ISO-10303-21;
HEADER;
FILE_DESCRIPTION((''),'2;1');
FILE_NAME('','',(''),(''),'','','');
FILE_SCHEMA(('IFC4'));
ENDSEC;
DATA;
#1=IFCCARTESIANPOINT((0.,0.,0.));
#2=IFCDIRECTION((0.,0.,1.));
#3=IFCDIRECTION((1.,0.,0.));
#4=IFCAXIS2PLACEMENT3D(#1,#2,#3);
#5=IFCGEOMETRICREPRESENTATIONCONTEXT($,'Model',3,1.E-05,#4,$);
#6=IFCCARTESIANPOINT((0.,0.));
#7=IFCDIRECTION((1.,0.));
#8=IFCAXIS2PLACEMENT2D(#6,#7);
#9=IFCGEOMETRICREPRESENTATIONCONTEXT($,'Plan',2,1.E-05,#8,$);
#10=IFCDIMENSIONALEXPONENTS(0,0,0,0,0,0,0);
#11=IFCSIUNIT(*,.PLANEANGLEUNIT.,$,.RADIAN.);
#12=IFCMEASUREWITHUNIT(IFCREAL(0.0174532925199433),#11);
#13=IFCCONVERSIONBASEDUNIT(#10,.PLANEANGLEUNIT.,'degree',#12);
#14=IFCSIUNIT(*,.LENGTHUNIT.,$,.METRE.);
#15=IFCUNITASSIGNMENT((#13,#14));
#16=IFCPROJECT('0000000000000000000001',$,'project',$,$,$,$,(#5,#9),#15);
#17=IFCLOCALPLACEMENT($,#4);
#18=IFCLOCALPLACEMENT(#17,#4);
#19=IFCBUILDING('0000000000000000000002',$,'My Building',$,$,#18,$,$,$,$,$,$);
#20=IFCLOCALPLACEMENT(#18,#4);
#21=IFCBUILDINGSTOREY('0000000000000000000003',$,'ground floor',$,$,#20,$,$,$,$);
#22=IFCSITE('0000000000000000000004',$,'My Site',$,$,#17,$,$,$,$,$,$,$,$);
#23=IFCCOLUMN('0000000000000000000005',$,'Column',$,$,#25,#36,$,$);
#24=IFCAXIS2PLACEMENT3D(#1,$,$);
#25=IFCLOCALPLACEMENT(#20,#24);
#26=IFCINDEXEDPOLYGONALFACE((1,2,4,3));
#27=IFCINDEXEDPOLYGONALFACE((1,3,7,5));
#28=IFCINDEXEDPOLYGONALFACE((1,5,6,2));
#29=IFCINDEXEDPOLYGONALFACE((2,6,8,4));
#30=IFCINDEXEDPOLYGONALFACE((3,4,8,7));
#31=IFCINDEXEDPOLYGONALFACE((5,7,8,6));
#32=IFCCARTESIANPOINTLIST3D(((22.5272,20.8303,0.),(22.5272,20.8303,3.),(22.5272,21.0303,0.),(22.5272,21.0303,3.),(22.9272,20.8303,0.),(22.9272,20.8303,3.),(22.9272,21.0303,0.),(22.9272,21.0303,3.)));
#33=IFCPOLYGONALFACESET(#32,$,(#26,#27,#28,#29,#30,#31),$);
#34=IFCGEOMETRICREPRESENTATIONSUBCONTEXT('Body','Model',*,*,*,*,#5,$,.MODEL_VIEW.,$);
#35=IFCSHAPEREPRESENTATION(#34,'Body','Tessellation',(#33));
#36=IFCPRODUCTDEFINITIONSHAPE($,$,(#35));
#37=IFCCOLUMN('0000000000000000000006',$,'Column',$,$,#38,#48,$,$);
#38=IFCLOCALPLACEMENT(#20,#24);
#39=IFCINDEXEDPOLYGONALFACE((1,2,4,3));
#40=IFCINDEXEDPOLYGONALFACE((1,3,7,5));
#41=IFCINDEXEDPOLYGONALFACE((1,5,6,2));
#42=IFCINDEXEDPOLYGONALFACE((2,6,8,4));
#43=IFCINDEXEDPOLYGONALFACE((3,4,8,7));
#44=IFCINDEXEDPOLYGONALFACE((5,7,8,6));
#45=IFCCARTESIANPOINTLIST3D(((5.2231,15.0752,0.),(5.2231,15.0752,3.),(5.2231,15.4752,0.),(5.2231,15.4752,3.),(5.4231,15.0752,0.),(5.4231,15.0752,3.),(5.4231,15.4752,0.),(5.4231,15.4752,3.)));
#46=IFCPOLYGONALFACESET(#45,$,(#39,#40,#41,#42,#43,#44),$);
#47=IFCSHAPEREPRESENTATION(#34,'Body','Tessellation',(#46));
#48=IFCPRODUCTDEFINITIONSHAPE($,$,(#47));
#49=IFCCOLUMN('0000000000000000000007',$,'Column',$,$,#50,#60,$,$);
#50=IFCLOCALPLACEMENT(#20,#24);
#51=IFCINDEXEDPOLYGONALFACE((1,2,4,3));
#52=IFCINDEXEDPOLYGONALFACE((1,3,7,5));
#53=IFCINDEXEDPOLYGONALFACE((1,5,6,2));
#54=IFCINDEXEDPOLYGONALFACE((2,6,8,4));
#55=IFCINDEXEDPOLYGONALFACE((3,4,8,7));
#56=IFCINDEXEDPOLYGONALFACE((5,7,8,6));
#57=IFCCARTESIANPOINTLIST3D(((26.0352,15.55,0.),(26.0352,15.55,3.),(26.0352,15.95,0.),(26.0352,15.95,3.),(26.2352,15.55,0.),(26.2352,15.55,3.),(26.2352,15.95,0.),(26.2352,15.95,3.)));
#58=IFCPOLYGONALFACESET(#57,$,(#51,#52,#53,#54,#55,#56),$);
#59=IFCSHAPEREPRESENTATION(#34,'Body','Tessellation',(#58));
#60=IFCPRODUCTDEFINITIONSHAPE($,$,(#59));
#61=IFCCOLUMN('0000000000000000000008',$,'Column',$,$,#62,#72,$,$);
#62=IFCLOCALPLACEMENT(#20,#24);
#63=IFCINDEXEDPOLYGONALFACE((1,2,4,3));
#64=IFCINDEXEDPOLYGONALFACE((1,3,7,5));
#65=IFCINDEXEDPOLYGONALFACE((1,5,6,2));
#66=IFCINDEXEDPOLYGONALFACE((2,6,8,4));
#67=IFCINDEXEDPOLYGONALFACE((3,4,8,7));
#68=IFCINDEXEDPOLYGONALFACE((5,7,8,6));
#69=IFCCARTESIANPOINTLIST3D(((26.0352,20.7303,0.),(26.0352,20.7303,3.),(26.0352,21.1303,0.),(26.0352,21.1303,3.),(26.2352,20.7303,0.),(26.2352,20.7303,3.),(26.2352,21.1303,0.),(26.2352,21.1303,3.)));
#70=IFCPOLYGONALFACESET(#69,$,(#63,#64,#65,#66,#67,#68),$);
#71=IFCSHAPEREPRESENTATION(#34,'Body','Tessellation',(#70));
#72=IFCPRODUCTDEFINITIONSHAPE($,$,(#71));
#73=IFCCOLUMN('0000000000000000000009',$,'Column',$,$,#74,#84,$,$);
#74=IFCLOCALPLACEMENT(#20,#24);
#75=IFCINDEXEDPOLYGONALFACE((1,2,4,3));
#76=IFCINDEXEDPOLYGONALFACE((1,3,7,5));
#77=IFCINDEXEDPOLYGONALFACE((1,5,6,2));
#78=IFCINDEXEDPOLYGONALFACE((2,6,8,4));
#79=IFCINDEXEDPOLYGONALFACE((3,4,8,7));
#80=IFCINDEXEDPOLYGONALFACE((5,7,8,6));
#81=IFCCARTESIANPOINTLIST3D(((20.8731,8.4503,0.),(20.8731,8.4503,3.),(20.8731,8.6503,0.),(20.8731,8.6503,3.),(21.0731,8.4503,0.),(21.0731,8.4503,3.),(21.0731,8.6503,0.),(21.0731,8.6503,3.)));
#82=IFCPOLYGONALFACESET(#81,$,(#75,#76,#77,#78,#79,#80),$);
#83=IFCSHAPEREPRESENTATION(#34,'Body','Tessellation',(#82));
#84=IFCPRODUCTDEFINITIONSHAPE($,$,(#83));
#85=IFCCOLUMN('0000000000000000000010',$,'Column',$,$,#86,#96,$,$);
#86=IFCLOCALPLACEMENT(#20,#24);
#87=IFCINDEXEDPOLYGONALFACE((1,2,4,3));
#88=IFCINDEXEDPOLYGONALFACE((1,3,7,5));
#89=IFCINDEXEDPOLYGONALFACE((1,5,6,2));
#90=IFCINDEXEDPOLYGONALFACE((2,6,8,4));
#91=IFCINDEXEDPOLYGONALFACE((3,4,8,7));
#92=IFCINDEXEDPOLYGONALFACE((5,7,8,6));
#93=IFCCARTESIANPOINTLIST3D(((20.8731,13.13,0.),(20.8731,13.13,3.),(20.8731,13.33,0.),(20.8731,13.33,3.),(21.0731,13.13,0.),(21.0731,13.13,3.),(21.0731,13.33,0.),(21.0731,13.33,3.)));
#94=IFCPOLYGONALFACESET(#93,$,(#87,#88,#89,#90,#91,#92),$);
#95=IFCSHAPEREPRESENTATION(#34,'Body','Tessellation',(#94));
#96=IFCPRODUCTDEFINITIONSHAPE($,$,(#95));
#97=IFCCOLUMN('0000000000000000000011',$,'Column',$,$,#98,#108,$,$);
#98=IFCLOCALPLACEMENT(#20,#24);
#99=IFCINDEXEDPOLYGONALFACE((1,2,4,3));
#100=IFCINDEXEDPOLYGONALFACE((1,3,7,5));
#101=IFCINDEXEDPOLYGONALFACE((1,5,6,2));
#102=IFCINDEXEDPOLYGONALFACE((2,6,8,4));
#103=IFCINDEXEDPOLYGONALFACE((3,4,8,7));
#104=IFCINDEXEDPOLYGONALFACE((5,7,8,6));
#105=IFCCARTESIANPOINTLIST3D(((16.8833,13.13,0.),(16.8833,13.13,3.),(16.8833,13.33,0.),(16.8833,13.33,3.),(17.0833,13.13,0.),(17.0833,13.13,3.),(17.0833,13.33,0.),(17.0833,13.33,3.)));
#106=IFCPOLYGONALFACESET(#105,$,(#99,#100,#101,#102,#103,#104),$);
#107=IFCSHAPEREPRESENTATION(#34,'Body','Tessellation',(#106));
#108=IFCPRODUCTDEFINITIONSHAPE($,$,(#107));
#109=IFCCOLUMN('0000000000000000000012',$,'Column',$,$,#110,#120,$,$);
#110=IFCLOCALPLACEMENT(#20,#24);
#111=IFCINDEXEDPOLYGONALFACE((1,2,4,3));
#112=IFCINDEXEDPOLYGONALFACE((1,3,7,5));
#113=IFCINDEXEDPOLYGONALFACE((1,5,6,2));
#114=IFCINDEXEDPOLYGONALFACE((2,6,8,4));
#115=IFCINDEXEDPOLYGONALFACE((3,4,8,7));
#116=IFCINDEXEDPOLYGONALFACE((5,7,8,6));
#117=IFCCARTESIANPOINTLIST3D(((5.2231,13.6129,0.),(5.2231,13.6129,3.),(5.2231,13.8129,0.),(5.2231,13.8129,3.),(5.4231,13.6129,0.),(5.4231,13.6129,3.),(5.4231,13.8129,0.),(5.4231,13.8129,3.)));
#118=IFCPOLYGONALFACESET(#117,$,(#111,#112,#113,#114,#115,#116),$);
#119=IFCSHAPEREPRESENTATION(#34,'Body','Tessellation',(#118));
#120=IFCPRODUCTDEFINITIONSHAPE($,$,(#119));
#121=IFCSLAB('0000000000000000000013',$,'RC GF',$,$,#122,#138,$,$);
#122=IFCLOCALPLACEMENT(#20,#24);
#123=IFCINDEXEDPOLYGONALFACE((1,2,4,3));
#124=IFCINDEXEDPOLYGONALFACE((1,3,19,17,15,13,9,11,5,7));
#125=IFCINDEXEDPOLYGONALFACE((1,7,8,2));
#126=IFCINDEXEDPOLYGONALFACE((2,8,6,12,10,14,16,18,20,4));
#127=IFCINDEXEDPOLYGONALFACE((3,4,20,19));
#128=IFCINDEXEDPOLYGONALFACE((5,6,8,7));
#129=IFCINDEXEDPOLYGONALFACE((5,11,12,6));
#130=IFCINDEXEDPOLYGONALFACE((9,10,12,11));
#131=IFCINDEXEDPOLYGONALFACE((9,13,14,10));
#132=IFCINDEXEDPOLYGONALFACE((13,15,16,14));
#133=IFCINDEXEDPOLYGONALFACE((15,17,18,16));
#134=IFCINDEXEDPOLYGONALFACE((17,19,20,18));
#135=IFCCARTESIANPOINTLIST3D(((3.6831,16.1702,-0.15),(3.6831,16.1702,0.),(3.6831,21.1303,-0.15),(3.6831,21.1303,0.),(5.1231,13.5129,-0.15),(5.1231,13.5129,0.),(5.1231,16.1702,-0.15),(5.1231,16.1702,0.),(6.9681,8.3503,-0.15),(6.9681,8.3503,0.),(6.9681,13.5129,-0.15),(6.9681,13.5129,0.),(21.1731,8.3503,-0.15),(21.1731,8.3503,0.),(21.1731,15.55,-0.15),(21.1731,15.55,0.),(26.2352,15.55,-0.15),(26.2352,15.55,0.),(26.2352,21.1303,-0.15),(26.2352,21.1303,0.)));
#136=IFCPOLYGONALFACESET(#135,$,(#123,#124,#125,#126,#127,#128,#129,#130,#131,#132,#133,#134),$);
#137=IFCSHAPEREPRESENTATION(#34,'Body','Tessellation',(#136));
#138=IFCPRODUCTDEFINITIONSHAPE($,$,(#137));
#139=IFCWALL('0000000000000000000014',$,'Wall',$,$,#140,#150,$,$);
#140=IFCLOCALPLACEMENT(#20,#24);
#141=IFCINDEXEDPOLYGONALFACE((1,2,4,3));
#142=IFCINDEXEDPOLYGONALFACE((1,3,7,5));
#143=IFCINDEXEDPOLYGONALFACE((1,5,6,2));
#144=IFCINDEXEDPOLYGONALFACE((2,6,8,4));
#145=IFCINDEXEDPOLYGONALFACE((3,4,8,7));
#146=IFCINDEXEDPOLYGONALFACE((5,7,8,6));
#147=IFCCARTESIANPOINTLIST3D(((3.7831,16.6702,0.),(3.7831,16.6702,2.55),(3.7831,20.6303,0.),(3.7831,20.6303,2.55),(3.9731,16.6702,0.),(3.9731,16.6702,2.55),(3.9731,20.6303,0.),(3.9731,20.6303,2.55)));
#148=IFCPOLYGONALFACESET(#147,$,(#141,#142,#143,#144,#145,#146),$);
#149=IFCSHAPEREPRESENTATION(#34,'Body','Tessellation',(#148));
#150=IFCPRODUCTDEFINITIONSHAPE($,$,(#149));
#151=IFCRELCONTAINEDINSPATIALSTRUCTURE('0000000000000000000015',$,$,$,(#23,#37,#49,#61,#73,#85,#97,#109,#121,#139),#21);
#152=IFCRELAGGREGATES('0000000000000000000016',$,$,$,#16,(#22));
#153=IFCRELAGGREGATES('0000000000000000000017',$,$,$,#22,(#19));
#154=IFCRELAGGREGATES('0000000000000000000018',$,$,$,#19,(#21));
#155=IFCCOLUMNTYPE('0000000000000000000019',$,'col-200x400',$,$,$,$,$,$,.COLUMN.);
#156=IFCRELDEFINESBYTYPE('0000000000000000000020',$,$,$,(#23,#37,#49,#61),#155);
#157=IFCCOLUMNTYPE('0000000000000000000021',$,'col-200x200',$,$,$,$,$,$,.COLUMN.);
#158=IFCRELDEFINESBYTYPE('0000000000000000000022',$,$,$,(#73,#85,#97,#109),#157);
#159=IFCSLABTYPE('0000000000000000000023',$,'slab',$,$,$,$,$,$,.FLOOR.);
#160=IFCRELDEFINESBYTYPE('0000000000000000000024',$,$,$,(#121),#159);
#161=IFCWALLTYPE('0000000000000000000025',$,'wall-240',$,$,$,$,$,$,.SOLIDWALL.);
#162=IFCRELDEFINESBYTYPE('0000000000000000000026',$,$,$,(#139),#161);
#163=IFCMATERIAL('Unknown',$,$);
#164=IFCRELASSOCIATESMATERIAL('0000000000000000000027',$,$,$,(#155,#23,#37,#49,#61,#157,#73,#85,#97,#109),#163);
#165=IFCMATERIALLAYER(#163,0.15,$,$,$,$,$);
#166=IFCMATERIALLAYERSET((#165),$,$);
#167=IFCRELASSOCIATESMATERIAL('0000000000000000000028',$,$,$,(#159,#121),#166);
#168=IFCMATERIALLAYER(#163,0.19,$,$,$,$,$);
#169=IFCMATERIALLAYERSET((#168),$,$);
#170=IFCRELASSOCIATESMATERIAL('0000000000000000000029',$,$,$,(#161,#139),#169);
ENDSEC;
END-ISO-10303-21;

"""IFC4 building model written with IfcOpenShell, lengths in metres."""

from ifc_helpers import new_model, entity, si_unit, converted_unit, frame, origin_with_axes, origin_2d_with_axis, place, context, subcontext, project, spatial, line, indexed_curve, rectangle, outline, extrude, material, layer, layer_set, layer_usage, material_profile, profile_set, profile_usage, type_object, element, save


model = new_model("IFC4")

# Units and contexts
model_context = context("Model", 3, precision=1e-05, world=origin_with_axes())
plan_context = context("Plan", 2, precision=1e-05, world=origin_2d_with_axis())
body_context = subcontext(model_context, "Body", "Model", "MODEL_VIEW")
ifc_project = project(units=[converted_unit("PLANEANGLEUNIT", "degree", entity("IfcReal", 0.0174532925199433), si_unit("PLANEANGLEUNIT", "RADIAN"), dimensions=[0, 0, 0, 0, 0, 0, 0]), si_unit("LENGTHUNIT", "METRE")], contexts=[model_context, plan_context])

# Site, building, storey
site_placement = place(None, origin_with_axes())
site = spatial("IfcSite", under=ifc_project, at=site_placement, Name="My Site")
building_placement = place(site_placement, origin_with_axes())
building = spatial("IfcBuilding", under=site, at=building_placement, Name="My Building")
storey_placement = place(building_placement, origin_with_axes())
storey = spatial("IfcBuildingStorey", under=building, at=storey_placement, Name="ground floor")

# Columns
ifc_material = material(Name="Unknown")
ifc_material_profile_1 = material_profile(ifc_material, rectangle(XDim=0.2, YDim=0.4))
ifc_profile_set_1 = profile_set([ifc_material_profile_1])
column_type_1 = type_object("IfcColumnType", Name="col-200x400", PredefinedType="COLUMN", material=ifc_profile_set_1)
ifc_profile_usage_1 = profile_usage(ifc_profile_set_1, cardinal=1)
column_1_placement = place(storey_placement, frame((22.5272, 20.8303, 0.0), z_axis=(0.0, 0.0, 1.0), x_axis=(0.0, -1.0, 0.0)))
element("IfcColumn", 1, at=column_1_placement, inside=storey, type_object=column_type_1, material=ifc_profile_usage_1, Name="Column", context=body_context, shape_type="SweptSolid", body=[
    extrude(rectangle(XDim=0.2, YDim=0.4), frame((-0.1, 0.2, 0.0), z_axis=(0.0, 0.0, 1.0), x_axis=(1.0, 0.0, 0.0)), (0.0, 0.0, 1.0), 3.0),
])
ifc_profile_usage_2 = profile_usage(ifc_profile_set_1, cardinal=1)
column_2_placement = place(storey_placement, frame((5.4231, 15.0752, 0.0), z_axis=(0.0, 0.0, 1.0), x_axis=(1.0, 0.0, 0.0)))
element("IfcColumn", 2, at=column_2_placement, inside=storey, type_object=column_type_1, material=ifc_profile_usage_2, Name="Column", context=body_context, shape_type="SweptSolid", body=[
    extrude(rectangle(XDim=0.2, YDim=0.4), frame((-0.1, 0.2, 0.0), z_axis=(0.0, 0.0, 1.0), x_axis=(1.0, 0.0, 0.0)), (0.0, 0.0, 1.0), 3.0),
])
ifc_profile_usage_3 = profile_usage(ifc_profile_set_1, cardinal=1)
column_3_placement = place(storey_placement, frame((26.2352, 15.55, 0.0), z_axis=(0.0, 0.0, 1.0), x_axis=(1.0, 0.0, 0.0)))
element("IfcColumn", 3, at=column_3_placement, inside=storey, type_object=column_type_1, material=ifc_profile_usage_3, Name="Column", context=body_context, shape_type="SweptSolid", body=[
    extrude(rectangle(XDim=0.2, YDim=0.4), frame((-0.1, 0.2, 0.0), z_axis=(0.0, 0.0, 1.0), x_axis=(1.0, 0.0, 0.0)), (0.0, 0.0, 1.0), 3.0),
])
ifc_profile_usage_4 = profile_usage(ifc_profile_set_1, cardinal=1)
column_4_placement = place(storey_placement, frame((26.2352, 20.7303, 0.0), z_axis=(0.0, 0.0, 1.0), x_axis=(1.0, 0.0, 0.0)))
element("IfcColumn", 4, at=column_4_placement, inside=storey, type_object=column_type_1, material=ifc_profile_usage_4, Name="Column", context=body_context, shape_type="SweptSolid", body=[
    extrude(rectangle(XDim=0.2, YDim=0.4), frame((-0.1, 0.2, 0.0), z_axis=(0.0, 0.0, 1.0), x_axis=(1.0, 0.0, 0.0)), (0.0, 0.0, 1.0), 3.0),
])
ifc_material_profile_2 = material_profile(ifc_material, rectangle(XDim=0.2, YDim=0.2))
ifc_profile_set_2 = profile_set([ifc_material_profile_2])
ifc_profile_usage_5 = profile_usage(ifc_profile_set_2, cardinal=1)
column_type_2 = type_object("IfcColumnType", Name="col-200x200", PredefinedType="COLUMN", material=ifc_profile_set_2)
column_5_placement = place(storey_placement, frame((21.0731, 8.4503, 0.0), z_axis=(0.0, 0.0, 1.0), x_axis=(1.0, 0.0, 0.0)))
element("IfcColumn", 5, at=column_5_placement, inside=storey, type_object=column_type_2, material=ifc_profile_usage_5, Name="Column", context=body_context, shape_type="SweptSolid", body=[
    extrude(rectangle(XDim=0.2, YDim=0.2), frame((-0.1, 0.1, 0.0), z_axis=(0.0, 0.0, 1.0), x_axis=(1.0, 0.0, 0.0)), (0.0, 0.0, 1.0), 3.0),
])
ifc_profile_usage_6 = profile_usage(ifc_profile_set_2, cardinal=1)
column_6_placement = place(storey_placement, frame((21.0731, 13.13, 0.0), z_axis=(0.0, 0.0, 1.0), x_axis=(1.0, 0.0, 0.0)))
element("IfcColumn", 6, at=column_6_placement, inside=storey, type_object=column_type_2, material=ifc_profile_usage_6, Name="Column", context=body_context, shape_type="SweptSolid", body=[
    extrude(rectangle(XDim=0.2, YDim=0.2), frame((-0.1, 0.1, 0.0), z_axis=(0.0, 0.0, 1.0), x_axis=(1.0, 0.0, 0.0)), (0.0, 0.0, 1.0), 3.0),
])
ifc_profile_usage_7 = profile_usage(ifc_profile_set_2, cardinal=1)
column_7_placement = place(storey_placement, frame((17.0833, 13.13, 0.0), z_axis=(0.0, 0.0, 1.0), x_axis=(1.0, 0.0, 0.0)))
element("IfcColumn", 7, at=column_7_placement, inside=storey, type_object=column_type_2, material=ifc_profile_usage_7, Name="Column", context=body_context, shape_type="SweptSolid", body=[
    extrude(rectangle(XDim=0.2, YDim=0.2), frame((-0.1, 0.1, 0.0), z_axis=(0.0, 0.0, 1.0), x_axis=(1.0, 0.0, 0.0)), (0.0, 0.0, 1.0), 3.0),
])
ifc_profile_usage_8 = profile_usage(ifc_profile_set_2, cardinal=1)
column_8_placement = place(storey_placement, frame((5.4231, 13.6129, 0.0), z_axis=(0.0, 0.0, 1.0), x_axis=(1.0, 0.0, 0.0)))
element("IfcColumn", 8, at=column_8_placement, inside=storey, type_object=column_type_2, material=ifc_profile_usage_8, Name="Column", context=body_context, shape_type="SweptSolid", body=[
    extrude(rectangle(XDim=0.2, YDim=0.2), frame((-0.1, 0.1, 0.0), z_axis=(0.0, 0.0, 1.0), x_axis=(1.0, 0.0, 0.0)), (0.0, 0.0, 1.0), 3.0),
])

# Slab
ifc_layer_1 = layer(ifc_material, 0.15)
ifc_layer_set_1 = layer_set([ifc_layer_1])
ifc_layer_usage_1 = layer_usage(ifc_layer_set_1, "AXIS3", "POSITIVE", 0.0)
slab_type = type_object("IfcSlabType", Name="slab", PredefinedType="FLOOR", material=ifc_layer_set_1)
slab_placement = place(storey_placement, frame((6.9681, 8.3503, -0.15), z_axis=(0.0, 0.0, 1.0), x_axis=(1.0, 0.0, 0.0)))
element("IfcSlab", 9, at=slab_placement, inside=storey, type_object=slab_type, material=ifc_layer_usage_1, Name="RC GF", context=body_context, shape_type="SweptSolid", body=[
    extrude(outline(indexed_curve([(14.205, 7.1996), (19.2671, 7.1996), (19.2671, 12.78), (-3.285, 12.78), (-3.285, 7.8199), (-1.845, 7.8199), (-1.845, 5.1626), (0.0, 5.1626), (0.0, 0.0), (14.205, 0.0)], segments=[line(3, 2), line(2, 1), line(1, 10), line(10, 9), line(9, 8), line(8, 7), line(7, 6), line(6, 5), line(5, 4), line(4, 3)], self_intersect=False)), None, (0.0, 0.0, 1.0), 0.15),
])

# Wall
ifc_layer_2 = layer(ifc_material, 0.19)
ifc_layer_set_2 = layer_set([ifc_layer_2])
ifc_layer_usage_2 = layer_usage(ifc_layer_set_2, "AXIS2", "POSITIVE", 0.0)
wall_type = type_object("IfcWallType", Name="wall-240", PredefinedType="SOLIDWALL", material=ifc_layer_set_2)
wall_placement = place(storey_placement, frame((3.7831, 20.6303, 0.0), z_axis=(0.0, 0.0, 1.0), x_axis=(-0.000001, -1.0, 0.0)))
element("IfcWall", 10, at=wall_placement, inside=storey, type_object=wall_type, material=ifc_layer_usage_2, Name="Wall", context=body_context, shape_type="SweptSolid", body=[
    extrude(outline(indexed_curve([(0.0, 0.0), (0.0, 0.19), (3.9601, 0.19), (3.9601, 0.0), (0.0, 0.0)], self_intersect=False)), origin_with_axes(), (0.0, 0.0, 1.0), 2.55),
])

save(model, "model.ifc")
